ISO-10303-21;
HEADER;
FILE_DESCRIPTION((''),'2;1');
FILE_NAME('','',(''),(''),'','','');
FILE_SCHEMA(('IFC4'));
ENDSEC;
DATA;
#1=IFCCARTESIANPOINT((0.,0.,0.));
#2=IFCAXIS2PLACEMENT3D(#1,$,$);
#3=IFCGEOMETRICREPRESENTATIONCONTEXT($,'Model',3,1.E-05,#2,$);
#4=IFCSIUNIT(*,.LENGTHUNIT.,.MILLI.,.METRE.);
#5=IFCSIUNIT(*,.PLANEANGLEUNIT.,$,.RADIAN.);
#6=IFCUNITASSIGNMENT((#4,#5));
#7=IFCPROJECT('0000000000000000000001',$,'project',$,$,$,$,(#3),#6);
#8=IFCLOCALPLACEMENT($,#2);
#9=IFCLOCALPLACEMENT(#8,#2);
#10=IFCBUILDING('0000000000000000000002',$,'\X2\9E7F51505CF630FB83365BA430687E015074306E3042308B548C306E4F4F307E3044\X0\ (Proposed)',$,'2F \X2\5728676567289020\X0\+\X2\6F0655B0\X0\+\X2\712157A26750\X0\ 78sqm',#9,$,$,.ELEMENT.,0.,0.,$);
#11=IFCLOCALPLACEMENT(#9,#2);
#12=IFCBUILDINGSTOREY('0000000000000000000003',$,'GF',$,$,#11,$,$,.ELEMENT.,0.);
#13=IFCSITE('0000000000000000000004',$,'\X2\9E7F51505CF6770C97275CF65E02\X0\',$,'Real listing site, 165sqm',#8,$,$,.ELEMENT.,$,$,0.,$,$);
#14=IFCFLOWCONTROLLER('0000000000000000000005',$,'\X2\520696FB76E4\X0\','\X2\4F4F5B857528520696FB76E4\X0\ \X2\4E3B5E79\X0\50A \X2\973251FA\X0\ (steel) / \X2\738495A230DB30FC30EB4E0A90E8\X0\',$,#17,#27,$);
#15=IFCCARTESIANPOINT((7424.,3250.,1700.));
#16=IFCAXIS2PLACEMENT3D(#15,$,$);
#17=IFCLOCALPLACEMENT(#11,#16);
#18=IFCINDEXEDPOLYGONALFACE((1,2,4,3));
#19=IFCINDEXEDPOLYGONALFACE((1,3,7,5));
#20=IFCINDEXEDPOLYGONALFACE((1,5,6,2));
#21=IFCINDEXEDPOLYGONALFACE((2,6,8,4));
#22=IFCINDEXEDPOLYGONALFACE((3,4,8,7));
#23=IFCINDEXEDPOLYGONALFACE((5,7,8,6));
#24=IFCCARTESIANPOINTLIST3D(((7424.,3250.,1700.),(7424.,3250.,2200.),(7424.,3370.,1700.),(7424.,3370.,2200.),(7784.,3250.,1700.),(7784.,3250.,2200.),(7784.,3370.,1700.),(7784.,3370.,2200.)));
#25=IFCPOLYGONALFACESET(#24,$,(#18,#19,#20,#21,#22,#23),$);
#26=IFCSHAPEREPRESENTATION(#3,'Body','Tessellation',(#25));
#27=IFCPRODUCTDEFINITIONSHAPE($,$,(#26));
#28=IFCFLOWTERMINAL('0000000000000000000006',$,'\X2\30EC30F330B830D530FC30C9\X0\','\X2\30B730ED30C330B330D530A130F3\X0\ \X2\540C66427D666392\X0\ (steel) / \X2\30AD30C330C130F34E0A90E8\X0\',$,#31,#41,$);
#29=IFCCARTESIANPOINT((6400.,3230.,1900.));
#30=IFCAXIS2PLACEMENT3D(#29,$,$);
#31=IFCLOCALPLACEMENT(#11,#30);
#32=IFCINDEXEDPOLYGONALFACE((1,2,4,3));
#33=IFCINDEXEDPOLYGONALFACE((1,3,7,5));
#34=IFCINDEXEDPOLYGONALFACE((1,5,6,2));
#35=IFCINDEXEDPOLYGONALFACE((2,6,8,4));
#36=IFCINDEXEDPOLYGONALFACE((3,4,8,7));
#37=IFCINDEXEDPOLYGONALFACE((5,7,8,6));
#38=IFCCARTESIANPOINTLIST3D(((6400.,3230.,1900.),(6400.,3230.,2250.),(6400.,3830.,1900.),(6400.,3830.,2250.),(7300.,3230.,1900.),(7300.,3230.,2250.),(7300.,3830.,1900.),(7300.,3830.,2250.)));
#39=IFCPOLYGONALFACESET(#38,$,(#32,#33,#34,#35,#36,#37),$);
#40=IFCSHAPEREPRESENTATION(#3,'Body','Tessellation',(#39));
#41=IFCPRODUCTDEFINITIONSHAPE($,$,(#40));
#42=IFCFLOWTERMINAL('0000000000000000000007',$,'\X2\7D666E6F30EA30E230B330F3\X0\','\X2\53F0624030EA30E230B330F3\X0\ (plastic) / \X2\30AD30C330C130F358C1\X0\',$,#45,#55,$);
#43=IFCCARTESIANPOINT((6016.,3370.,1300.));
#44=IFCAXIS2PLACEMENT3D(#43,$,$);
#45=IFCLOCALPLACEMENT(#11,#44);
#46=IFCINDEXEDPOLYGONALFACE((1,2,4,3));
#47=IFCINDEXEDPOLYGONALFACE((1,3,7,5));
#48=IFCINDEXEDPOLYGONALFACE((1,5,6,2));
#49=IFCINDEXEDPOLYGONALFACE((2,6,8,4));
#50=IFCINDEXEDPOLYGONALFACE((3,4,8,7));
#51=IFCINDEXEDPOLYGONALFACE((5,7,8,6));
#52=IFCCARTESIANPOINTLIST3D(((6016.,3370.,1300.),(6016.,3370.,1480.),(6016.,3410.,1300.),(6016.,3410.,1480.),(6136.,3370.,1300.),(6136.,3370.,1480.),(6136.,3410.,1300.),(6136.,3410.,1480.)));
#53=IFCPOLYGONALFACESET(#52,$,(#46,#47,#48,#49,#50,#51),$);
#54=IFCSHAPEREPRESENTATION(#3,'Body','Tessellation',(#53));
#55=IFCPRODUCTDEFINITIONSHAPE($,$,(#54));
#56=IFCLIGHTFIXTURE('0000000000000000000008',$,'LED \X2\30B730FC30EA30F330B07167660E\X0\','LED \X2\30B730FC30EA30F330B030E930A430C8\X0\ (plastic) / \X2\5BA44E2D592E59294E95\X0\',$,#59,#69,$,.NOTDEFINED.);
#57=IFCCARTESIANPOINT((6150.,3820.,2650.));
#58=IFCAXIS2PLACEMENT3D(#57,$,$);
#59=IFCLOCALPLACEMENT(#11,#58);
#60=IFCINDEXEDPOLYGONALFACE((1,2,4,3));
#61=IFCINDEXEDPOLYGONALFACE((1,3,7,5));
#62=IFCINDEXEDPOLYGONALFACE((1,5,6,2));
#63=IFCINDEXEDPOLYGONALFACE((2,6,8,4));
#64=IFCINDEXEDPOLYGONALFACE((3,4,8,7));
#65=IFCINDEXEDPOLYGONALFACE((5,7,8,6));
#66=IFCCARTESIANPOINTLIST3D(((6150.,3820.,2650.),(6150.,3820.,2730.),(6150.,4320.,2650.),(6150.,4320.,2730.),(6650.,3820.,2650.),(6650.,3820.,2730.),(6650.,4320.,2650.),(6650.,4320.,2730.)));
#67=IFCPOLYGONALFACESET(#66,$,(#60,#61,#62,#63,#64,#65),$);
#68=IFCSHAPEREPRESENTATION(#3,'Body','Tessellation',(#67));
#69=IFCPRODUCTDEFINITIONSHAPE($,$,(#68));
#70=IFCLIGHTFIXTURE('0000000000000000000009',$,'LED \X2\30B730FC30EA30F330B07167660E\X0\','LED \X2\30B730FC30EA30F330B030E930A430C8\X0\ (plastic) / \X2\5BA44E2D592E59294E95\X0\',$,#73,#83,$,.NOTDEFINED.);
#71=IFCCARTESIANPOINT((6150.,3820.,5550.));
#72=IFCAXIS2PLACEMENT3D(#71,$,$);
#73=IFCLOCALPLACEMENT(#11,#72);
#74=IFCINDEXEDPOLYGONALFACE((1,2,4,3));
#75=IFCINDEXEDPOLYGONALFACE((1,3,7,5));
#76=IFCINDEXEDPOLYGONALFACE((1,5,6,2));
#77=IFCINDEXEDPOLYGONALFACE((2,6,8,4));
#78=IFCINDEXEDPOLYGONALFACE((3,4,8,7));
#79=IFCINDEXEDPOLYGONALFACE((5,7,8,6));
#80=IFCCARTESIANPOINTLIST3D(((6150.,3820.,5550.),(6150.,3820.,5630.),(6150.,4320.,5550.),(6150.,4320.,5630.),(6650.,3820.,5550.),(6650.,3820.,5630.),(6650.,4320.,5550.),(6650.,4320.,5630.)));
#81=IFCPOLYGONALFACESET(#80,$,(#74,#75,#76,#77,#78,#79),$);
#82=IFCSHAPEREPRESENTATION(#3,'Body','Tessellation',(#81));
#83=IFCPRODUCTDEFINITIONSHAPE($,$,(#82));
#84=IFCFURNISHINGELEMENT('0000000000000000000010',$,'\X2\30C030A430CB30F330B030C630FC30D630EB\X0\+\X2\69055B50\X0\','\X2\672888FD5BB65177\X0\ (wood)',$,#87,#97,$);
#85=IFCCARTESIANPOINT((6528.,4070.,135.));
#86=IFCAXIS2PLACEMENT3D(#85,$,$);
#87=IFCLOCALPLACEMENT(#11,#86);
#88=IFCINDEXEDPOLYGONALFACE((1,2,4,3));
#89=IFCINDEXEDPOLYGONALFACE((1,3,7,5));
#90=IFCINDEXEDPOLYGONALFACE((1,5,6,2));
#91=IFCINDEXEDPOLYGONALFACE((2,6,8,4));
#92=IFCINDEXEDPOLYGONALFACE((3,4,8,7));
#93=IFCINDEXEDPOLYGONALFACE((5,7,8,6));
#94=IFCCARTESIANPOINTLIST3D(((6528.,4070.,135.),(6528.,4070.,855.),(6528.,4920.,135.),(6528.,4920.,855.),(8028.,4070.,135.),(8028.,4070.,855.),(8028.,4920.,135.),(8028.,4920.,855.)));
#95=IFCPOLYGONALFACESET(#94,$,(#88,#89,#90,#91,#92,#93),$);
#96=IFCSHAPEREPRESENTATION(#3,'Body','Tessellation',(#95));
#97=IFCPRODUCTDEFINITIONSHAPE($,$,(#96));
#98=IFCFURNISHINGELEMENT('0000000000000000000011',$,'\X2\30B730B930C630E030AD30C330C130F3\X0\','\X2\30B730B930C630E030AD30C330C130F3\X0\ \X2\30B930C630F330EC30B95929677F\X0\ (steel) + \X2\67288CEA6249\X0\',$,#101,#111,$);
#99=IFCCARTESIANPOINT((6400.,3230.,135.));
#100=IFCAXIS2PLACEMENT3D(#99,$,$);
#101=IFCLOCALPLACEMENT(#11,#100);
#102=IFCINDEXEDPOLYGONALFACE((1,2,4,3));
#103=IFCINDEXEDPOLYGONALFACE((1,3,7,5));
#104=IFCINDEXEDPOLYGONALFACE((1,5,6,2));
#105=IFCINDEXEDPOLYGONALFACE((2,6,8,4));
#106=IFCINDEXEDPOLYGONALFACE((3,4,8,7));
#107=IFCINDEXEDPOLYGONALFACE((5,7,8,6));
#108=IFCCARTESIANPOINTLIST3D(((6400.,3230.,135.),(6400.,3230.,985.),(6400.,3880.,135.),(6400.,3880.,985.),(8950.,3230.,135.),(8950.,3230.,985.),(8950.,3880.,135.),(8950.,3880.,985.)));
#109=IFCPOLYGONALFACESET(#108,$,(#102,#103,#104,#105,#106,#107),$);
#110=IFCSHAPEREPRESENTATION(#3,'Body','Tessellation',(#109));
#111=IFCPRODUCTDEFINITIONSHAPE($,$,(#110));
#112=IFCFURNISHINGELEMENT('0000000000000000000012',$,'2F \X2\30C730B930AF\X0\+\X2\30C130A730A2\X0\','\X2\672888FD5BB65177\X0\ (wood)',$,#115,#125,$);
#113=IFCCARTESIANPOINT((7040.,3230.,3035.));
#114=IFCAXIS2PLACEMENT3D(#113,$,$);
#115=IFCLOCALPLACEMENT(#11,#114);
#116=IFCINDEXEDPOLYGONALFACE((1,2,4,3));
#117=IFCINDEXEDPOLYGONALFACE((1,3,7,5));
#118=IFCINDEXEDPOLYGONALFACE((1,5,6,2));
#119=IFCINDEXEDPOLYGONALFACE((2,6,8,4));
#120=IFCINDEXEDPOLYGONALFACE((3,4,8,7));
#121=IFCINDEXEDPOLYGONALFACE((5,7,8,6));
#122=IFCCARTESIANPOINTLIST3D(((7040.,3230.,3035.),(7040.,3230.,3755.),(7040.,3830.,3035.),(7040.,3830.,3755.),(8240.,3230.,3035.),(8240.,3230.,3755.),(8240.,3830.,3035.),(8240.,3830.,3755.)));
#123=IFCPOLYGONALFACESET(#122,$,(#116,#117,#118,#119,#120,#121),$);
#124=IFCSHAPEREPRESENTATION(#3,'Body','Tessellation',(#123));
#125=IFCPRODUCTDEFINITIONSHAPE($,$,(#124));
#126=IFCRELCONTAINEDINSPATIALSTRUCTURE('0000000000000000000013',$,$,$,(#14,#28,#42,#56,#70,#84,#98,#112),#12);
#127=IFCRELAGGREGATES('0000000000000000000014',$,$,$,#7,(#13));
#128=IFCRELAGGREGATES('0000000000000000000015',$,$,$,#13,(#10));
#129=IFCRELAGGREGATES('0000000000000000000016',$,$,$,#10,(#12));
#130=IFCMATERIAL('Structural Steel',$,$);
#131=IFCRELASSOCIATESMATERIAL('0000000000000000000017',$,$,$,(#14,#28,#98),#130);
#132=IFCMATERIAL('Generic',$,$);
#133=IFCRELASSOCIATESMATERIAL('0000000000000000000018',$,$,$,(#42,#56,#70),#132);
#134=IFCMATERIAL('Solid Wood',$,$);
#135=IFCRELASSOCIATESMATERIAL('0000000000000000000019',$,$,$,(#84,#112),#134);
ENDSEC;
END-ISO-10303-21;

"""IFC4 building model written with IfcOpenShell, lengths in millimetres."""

from ifc_helpers import new_model, si_unit, frame, frame_2d, origin, place, context, project, spatial, rectangle, extrude, material, element, save


model = new_model("IFC4")

# Units and contexts
model_context = context("Model", 3, precision=1e-05, world=origin())
ifc_project = project(units=[si_unit("LENGTHUNIT", "METRE", prefix="MILLI"), si_unit("PLANEANGLEUNIT", "RADIAN")], contexts=[model_context])

# Site, building, storey
site_placement = place(None, origin())
site = spatial("IfcSite", under=ifc_project, at=site_placement, Name="鹿児島県霧島市", ObjectType="Real listing site, 165sqm", CompositionType="ELEMENT", RefElevation=0.0)
building_placement = place(site_placement, origin())
building = spatial("IfcBuilding", under=site, at=building_placement, Name="鹿児島・茶室と縁側のある和の住まい (Proposed)", ObjectType="2F 在来木造+漆喰+無垢材 78sqm", CompositionType="ELEMENT", ElevationOfRefHeight=0.0, ElevationOfTerrain=0.0)
storey_placement = place(building_placement, origin())
storey = spatial("IfcBuildingStorey", under=building, at=storey_placement, Name="GF", CompositionType="ELEMENT", Elevation=0.0)

# Shared definitions
ifc_material_1 = material(Name="Solid Wood")

# Shared definitions
ifc_material_2 = material(Name="Structural Steel")

# Flow controller
flow_controller_placement = place(storey_placement, frame((7424.0, 3250.0, 1700.0)))
element("IfcFlowController", 1, at=flow_controller_placement, inside=storey, material=ifc_material_2, Name="分電盤", Description="住宅用分電盤 主幹50A 露出 (steel) / 玄関ホール上部", context=model_context, shape_type="SweptSolid", body=[
    extrude(rectangle(XDim=360.0, YDim=120.0, at=frame_2d((180.0, 60.0))), frame((7424.0, 3250.0, 1700.0)), (0.0, 0.0, 1.0), 500.0),
])

# Flow terminals
flow_terminal_1_placement = place(storey_placement, frame((6400.0, 3230.0, 1900.0)))
element("IfcFlowTerminal", 2, at=flow_terminal_1_placement, inside=storey, material=ifc_material_2, Name="レンジフード", Description="シロッコファン 同時給排 (steel) / キッチン上部", context=model_context, shape_type="SweptSolid", body=[
    extrude(rectangle(XDim=900.0, YDim=600.0, at=frame_2d((450.0, 300.0))), frame((6400.0, 3230.0, 1900.0)), (0.0, 0.0, 1.0), 350.0),
])
ifc_material_3 = material(Name="Generic")
flow_terminal_2_placement = place(storey_placement, frame((6016.0, 3370.0, 1300.0)))
element("IfcFlowTerminal", 3, at=flow_terminal_2_placement, inside=storey, material=ifc_material_3, Name="給湯リモコン", Description="台所リモコン (plastic) / キッチン壁", context=model_context, shape_type="SweptSolid", body=[
    extrude(rectangle(XDim=120.0, YDim=40.0, at=frame_2d((60.0, 20.0))), frame((6016.0, 3370.0, 1300.0)), (0.0, 0.0, 1.0), 180.0),
])

# Light fixtures
light_fixture_1_placement = place(storey_placement, frame((6150.0, 3820.0, 2650.0)))
element("IfcLightFixture", 4, at=light_fixture_1_placement, inside=storey, material=ifc_material_3, Name="LED シーリング照明", Description="LED シーリングライト (plastic) / 室中央天井", PredefinedType="NOTDEFINED", context=model_context, shape_type="SweptSolid", body=[
    extrude(rectangle(XDim=500.0, YDim=500.0, at=frame_2d((250.0, 250.0))), frame((6150.0, 3820.0, 2650.0)), (0.0, 0.0, 1.0), 80.0),
])
light_fixture_2_placement = place(storey_placement, frame((6150.0, 3820.0, 5550.0)))
element("IfcLightFixture", 5, at=light_fixture_2_placement, inside=storey, material=ifc_material_3, Name="LED シーリング照明", Description="LED シーリングライト (plastic) / 室中央天井", PredefinedType="NOTDEFINED", context=model_context, shape_type="SweptSolid", body=[
    extrude(rectangle(XDim=500.0, YDim=500.0, at=frame_2d((250.0, 250.0))), frame((6150.0, 3820.0, 5550.0)), (0.0, 0.0, 1.0), 80.0),
])

# Furnishing elements
furnishing_1_placement = place(storey_placement, frame((6528.0, 4070.0, 135.0)))
element("IfcFurnishingElement", 6, at=furnishing_1_placement, inside=storey, material=ifc_material_1, Name="ダイニングテーブル+椅子", Description="木製家具 (wood)", context=model_context, shape_type="SweptSolid", body=[
    extrude(rectangle(XDim=1500.0, YDim=850.0, at=frame_2d((750.0, 425.0))), frame((6528.0, 4070.0, 135.0)), (0.0, 0.0, 1.0), 720.0),
])
furnishing_2_placement = place(storey_placement, frame((6400.0, 3230.0, 135.0)))
element("IfcFurnishingElement", 7, at=furnishing_2_placement, inside=storey, material=ifc_material_2, Name="システムキッチン", Description="システムキッチン ステンレス天板 (steel) + 木質扉", context=model_context, shape_type="SweptSolid", body=[
    extrude(rectangle(XDim=2550.0, YDim=650.0, at=frame_2d((1275.0, 325.0))), frame((6400.0, 3230.0, 135.0)), (0.0, 0.0, 1.0), 850.0),
])
furnishing_3_placement = place(storey_placement, frame((7040.0, 3230.0, 3035.0)))
element("IfcFurnishingElement", 8, at=furnishing_3_placement, inside=storey, material=ifc_material_1, Name="2F デスク+チェア", Description="木製家具 (wood)", context=model_context, shape_type="SweptSolid", body=[
    extrude(rectangle(XDim=1200.0, YDim=600.0, at=frame_2d((600.0, 300.0))), frame((7040.0, 3230.0, 3035.0)), (0.0, 0.0, 1.0), 720.0),
])

save(model, "model.ifc")
